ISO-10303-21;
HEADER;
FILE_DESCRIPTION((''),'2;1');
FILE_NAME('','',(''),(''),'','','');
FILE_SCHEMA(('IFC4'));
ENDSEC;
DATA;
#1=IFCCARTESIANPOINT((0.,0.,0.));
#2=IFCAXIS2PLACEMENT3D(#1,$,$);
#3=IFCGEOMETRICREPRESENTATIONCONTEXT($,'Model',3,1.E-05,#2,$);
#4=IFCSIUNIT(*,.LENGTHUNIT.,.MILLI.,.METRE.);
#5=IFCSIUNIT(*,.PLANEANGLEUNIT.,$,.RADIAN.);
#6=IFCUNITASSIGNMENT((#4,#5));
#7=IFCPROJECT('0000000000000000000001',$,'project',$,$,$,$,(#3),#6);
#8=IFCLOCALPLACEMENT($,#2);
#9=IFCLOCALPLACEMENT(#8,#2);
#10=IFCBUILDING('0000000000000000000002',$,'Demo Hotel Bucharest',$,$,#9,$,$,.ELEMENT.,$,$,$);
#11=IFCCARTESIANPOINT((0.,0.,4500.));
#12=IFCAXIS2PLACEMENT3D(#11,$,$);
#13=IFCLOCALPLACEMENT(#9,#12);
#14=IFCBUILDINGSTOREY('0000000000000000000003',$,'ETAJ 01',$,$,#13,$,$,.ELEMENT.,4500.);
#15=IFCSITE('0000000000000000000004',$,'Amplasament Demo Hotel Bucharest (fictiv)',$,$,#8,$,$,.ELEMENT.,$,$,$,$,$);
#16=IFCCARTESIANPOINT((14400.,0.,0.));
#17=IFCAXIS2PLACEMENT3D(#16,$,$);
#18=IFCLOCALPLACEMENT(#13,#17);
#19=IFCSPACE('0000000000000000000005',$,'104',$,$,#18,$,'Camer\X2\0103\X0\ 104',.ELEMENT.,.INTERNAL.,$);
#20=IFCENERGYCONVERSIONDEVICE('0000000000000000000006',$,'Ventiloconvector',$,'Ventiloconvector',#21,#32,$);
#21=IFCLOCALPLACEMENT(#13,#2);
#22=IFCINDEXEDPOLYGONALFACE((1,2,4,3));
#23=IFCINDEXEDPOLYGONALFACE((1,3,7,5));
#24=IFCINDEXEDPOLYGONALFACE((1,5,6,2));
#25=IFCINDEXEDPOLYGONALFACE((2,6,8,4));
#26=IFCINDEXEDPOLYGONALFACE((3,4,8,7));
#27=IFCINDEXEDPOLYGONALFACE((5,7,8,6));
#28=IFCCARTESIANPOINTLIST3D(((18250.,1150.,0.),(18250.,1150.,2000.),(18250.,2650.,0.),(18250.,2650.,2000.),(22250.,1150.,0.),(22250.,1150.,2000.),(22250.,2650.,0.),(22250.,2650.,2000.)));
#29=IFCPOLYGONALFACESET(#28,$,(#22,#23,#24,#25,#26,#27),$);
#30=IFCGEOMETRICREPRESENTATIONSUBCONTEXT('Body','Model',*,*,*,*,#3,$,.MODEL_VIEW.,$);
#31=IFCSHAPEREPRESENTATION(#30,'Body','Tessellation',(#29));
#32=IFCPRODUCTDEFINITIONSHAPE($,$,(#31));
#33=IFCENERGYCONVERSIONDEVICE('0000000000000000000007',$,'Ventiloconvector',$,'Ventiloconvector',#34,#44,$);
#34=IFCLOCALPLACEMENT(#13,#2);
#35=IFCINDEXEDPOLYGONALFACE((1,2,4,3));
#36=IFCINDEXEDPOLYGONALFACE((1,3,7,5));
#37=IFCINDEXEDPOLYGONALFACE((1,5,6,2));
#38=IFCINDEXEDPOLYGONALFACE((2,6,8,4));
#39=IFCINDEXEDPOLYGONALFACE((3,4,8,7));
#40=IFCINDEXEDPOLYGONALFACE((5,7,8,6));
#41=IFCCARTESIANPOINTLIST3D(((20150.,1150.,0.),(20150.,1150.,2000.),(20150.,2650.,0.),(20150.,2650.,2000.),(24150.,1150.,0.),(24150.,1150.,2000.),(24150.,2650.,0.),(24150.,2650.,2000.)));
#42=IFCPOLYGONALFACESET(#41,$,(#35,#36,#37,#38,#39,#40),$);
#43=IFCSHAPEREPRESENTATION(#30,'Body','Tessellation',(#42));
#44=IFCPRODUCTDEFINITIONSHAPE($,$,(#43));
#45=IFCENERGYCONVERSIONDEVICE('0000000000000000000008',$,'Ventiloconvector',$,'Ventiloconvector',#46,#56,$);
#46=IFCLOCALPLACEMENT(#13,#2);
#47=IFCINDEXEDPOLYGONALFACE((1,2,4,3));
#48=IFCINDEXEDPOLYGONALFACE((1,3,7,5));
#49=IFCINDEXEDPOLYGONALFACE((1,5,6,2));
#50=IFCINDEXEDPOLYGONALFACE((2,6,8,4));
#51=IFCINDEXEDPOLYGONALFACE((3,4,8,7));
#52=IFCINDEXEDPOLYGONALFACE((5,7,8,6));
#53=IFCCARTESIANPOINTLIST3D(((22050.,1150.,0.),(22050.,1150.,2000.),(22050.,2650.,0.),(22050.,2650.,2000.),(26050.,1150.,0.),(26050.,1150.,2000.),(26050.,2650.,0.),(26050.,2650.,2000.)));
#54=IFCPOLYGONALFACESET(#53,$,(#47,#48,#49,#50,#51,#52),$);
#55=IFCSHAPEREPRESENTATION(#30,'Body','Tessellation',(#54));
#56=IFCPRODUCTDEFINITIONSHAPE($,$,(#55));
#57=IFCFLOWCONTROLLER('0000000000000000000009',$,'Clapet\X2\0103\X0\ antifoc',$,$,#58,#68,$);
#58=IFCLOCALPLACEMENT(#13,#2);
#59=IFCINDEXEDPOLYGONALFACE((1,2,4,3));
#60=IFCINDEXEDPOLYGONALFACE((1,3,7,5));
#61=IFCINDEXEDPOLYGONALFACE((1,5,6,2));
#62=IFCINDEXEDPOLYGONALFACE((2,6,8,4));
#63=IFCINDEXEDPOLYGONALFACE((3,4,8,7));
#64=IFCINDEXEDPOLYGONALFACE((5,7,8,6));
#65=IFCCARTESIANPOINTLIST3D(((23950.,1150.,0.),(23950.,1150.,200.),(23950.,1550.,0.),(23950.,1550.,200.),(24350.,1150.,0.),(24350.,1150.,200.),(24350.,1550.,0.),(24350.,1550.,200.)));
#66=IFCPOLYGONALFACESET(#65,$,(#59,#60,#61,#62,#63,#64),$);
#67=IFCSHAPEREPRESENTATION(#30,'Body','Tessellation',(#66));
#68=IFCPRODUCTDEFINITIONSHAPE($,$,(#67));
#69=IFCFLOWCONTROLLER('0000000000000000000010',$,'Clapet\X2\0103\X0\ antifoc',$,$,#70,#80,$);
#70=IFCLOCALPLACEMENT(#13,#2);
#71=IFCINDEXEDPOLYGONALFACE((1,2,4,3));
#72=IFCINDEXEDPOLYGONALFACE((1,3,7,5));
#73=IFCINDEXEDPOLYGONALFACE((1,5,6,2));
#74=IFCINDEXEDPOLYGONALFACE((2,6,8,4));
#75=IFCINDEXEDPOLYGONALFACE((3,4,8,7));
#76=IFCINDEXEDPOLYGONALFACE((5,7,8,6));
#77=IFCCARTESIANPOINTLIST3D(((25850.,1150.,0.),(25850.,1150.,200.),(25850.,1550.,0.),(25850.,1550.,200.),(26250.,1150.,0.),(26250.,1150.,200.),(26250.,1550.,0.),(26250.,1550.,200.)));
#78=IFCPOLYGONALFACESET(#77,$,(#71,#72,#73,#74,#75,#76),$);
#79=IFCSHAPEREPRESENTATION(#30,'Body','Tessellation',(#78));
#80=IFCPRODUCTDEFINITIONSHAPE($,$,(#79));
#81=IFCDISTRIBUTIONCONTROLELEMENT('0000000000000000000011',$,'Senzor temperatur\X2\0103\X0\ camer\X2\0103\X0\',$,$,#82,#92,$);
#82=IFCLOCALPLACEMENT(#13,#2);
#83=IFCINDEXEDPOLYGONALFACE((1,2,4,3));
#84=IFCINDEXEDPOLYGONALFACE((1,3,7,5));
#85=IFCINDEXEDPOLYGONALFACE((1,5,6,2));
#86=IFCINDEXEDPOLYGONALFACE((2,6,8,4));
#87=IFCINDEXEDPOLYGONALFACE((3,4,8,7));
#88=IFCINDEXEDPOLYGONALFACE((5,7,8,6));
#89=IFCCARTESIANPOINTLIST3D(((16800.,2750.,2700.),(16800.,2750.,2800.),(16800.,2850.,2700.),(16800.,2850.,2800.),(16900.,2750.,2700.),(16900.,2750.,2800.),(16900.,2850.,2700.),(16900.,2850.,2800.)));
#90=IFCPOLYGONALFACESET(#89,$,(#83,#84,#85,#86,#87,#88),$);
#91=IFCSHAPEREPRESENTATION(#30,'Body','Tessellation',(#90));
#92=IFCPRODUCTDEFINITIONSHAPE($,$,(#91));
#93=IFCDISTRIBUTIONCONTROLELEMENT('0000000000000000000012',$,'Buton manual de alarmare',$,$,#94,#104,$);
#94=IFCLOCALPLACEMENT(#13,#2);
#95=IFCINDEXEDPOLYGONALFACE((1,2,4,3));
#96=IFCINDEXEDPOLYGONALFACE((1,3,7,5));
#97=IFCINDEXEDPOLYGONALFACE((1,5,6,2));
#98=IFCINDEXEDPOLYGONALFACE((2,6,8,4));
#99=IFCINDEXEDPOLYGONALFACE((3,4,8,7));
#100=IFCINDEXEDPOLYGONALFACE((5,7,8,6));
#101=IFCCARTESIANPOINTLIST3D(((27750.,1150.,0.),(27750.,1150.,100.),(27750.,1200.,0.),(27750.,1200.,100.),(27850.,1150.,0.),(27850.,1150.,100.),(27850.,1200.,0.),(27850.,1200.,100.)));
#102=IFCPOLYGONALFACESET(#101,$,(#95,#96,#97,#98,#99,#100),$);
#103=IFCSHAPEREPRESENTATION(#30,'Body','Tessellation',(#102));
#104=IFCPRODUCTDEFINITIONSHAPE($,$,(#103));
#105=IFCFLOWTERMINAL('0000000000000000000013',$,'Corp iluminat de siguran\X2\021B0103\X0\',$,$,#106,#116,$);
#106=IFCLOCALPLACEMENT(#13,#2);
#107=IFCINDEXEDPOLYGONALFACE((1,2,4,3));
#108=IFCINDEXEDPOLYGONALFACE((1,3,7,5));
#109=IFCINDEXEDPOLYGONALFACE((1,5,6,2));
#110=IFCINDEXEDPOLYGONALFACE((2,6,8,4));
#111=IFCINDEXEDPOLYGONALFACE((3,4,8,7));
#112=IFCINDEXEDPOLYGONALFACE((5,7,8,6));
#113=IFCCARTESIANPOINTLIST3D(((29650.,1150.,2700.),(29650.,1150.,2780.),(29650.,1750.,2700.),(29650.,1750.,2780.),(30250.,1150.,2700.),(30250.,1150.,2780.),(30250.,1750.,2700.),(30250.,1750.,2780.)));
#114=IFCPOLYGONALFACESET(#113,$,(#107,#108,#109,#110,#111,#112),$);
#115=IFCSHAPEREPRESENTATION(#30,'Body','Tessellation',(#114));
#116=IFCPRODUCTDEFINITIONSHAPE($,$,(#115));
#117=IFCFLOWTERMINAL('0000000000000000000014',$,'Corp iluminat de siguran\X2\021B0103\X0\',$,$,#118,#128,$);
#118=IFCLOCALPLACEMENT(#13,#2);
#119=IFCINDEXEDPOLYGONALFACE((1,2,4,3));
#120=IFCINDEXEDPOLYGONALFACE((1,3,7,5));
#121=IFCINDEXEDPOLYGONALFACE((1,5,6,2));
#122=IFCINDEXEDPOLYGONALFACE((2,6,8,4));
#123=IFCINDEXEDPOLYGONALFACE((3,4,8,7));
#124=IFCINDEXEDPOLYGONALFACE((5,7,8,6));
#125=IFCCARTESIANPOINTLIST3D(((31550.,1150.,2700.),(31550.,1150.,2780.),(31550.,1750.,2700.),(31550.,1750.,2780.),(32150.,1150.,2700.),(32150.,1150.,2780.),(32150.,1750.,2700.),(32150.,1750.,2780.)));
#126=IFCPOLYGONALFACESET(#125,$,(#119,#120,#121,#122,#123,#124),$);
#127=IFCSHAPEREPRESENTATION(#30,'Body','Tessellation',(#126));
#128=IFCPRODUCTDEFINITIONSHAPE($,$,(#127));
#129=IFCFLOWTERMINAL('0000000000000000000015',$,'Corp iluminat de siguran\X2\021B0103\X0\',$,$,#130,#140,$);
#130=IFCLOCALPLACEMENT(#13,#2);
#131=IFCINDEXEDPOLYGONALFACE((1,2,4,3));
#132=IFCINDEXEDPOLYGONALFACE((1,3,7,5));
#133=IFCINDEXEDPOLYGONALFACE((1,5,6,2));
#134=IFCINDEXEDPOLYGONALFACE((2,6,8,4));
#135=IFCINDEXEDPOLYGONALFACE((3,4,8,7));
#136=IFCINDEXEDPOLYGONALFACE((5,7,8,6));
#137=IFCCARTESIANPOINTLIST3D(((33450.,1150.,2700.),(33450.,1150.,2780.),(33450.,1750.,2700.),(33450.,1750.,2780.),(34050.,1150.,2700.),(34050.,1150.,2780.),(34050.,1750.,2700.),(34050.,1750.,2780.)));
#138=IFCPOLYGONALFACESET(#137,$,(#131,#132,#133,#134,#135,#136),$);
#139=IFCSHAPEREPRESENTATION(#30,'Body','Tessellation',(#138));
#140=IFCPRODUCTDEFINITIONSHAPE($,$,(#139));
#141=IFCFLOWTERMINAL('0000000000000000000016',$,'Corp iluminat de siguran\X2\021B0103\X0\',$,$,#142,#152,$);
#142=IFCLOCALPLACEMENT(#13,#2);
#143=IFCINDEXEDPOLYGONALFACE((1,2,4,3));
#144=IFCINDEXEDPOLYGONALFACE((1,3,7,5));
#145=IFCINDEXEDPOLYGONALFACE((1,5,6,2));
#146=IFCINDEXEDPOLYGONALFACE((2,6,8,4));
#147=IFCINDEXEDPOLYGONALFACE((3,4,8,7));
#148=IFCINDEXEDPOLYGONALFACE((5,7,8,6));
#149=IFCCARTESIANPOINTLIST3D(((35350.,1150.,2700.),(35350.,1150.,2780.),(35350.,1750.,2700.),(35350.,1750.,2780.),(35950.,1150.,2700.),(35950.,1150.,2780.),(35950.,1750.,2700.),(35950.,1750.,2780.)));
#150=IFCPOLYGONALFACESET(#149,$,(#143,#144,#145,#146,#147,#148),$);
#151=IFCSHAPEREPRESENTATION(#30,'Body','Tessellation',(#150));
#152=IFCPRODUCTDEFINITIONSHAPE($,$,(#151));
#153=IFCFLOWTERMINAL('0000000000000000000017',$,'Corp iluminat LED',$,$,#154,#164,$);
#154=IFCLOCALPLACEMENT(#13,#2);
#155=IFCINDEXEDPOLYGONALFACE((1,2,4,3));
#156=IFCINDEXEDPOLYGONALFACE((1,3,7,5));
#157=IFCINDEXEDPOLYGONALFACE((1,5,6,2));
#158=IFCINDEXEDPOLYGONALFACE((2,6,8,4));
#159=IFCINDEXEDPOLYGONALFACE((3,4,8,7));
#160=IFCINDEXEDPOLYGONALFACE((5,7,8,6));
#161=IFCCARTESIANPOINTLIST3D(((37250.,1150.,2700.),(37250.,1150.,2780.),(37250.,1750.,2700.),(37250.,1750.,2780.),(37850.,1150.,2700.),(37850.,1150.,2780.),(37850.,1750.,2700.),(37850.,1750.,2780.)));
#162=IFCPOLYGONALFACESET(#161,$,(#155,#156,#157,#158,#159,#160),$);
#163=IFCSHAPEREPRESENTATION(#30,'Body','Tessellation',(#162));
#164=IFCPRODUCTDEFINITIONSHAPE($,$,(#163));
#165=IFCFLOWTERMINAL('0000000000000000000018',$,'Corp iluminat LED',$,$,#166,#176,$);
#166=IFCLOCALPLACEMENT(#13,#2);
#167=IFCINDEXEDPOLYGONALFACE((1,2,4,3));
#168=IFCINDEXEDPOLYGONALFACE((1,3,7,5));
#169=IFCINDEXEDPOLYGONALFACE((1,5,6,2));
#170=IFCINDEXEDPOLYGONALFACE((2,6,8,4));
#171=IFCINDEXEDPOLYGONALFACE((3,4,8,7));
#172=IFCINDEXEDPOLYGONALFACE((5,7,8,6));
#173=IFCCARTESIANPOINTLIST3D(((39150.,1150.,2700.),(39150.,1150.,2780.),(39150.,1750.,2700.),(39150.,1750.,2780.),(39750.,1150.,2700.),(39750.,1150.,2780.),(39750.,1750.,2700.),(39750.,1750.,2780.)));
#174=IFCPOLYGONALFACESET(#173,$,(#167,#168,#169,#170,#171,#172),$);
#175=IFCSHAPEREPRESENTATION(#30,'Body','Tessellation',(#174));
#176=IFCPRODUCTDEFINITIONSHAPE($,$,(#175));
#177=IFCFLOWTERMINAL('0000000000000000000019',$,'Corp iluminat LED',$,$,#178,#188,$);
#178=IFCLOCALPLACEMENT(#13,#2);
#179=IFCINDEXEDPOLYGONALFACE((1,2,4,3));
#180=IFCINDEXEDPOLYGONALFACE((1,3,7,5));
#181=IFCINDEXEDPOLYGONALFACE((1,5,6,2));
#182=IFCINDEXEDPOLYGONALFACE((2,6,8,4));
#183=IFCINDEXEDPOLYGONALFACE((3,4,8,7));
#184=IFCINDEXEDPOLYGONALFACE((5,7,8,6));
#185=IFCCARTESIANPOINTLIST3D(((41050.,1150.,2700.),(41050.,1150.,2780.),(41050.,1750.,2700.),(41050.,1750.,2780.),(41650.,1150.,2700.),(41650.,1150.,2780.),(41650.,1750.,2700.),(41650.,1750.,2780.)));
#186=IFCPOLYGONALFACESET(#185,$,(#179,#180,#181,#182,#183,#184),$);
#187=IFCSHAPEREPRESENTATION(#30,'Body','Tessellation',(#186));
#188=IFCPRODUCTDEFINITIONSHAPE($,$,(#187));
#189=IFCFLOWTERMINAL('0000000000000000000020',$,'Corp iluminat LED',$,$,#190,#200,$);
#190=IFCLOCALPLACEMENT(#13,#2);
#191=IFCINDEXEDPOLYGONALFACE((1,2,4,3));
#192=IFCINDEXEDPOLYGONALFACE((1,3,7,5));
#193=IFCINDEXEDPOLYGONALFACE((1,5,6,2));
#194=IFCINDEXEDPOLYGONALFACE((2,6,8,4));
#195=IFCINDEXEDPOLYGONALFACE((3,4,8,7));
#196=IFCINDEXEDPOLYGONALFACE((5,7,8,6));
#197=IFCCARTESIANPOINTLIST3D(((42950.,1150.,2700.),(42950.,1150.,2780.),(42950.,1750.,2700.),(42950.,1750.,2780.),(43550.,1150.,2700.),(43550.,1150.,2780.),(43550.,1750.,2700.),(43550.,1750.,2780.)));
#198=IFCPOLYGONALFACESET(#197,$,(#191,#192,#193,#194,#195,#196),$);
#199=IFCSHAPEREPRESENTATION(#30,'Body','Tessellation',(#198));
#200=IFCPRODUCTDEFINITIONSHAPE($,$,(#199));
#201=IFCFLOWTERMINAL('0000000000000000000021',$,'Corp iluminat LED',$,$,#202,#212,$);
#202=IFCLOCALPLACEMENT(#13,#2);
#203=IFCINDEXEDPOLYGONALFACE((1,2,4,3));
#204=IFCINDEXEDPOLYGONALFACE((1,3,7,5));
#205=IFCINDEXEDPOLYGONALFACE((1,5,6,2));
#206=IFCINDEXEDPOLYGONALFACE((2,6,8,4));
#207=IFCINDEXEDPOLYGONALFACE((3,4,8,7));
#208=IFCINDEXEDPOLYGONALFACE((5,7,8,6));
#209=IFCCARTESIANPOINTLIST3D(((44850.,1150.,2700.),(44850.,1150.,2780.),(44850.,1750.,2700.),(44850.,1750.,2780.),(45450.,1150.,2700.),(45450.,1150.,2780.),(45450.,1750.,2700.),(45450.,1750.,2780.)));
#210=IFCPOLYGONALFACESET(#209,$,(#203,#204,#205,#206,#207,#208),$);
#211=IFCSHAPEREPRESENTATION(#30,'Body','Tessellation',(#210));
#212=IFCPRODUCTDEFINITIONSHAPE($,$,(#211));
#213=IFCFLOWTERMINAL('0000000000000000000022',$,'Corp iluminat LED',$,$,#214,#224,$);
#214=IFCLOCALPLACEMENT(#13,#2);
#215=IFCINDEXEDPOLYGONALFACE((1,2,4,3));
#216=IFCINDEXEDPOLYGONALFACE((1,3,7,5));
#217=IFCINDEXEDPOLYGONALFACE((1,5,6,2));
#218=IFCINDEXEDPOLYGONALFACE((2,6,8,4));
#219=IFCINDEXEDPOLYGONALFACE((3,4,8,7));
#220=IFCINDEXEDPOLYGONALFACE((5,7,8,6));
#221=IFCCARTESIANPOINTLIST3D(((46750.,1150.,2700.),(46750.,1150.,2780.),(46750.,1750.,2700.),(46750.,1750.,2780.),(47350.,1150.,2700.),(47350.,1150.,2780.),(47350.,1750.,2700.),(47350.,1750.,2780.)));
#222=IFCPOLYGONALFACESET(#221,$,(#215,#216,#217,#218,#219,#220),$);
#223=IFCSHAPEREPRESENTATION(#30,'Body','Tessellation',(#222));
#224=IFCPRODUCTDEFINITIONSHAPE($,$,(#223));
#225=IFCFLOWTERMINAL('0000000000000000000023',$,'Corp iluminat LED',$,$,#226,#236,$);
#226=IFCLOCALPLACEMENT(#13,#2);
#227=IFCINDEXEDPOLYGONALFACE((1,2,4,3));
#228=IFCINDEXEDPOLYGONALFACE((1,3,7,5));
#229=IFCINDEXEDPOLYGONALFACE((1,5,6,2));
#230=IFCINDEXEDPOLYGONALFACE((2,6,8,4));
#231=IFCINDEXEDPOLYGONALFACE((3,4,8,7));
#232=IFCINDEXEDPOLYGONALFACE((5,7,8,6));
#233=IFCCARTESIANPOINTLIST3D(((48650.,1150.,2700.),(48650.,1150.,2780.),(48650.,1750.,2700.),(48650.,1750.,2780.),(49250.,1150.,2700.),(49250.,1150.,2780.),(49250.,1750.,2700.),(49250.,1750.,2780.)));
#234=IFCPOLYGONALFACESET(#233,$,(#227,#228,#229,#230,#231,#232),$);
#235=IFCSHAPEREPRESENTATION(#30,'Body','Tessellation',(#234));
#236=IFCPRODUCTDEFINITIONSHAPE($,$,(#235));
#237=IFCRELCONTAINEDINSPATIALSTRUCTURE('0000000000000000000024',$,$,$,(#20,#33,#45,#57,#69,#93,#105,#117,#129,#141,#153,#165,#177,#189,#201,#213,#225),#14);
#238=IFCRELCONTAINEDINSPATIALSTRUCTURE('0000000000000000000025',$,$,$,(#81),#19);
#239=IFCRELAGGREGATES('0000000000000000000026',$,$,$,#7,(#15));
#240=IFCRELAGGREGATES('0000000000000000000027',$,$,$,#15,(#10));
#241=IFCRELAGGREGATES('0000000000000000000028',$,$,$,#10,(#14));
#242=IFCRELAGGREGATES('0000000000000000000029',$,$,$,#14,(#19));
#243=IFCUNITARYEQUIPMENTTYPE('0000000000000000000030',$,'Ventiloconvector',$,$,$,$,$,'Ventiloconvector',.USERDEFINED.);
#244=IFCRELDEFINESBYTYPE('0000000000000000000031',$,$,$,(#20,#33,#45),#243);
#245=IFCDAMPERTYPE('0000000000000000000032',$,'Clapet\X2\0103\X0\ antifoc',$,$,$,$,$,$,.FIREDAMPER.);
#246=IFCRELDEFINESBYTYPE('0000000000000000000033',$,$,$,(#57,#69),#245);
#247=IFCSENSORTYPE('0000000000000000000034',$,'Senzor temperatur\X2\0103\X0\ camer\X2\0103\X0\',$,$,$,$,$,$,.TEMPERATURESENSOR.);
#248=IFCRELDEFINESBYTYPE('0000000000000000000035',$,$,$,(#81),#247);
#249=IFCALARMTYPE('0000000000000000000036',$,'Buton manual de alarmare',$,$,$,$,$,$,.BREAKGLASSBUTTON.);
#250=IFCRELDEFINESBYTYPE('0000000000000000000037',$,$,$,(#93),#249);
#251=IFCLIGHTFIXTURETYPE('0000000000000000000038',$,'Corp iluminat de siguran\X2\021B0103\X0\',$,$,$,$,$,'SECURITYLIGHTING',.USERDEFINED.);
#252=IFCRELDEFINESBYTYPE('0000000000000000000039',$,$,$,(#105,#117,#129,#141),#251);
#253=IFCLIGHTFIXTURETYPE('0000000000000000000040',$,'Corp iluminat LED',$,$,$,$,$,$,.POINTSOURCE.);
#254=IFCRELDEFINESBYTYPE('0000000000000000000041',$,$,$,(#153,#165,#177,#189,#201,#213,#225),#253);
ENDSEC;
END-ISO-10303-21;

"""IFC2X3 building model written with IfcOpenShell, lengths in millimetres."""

from ifc_helpers import new_model, si_unit, frame, frame_2d, origin, place, context, subcontext, project, spatial, rectangle, extrude, type_object, element, save


model = new_model("IFC2X3")

# Units and contexts
model_context = context("Model", 3, precision=1e-05, world=origin())
body_context = subcontext(model_context, "Body", "Model", "MODEL_VIEW")
ifc_project = project(units=[si_unit("LENGTHUNIT", "METRE", prefix="MILLI"), si_unit("PLANEANGLEUNIT", "RADIAN")], contexts=[model_context])

# Site, building, storey
site_placement = place(None, origin())
site = spatial("IfcSite", under=ifc_project, at=site_placement, Name="Amplasament Demo Hotel Bucharest (fictiv)", CompositionType="ELEMENT")
building_placement = place(site_placement, origin())
building = spatial("IfcBuilding", under=site, at=building_placement, Name="Demo Hotel Bucharest", CompositionType="ELEMENT")
storey_placement = place(building_placement, frame((0.0, 0.0, 4500.0)))
storey = spatial("IfcBuildingStorey", under=building, at=storey_placement, Name="ETAJ 01", CompositionType="ELEMENT", Elevation=4500.0)

# Energy conversion devices
unitary_equipment_type = type_object("IfcUnitaryEquipmentType", Name="Ventiloconvector", ElementType="Ventiloconvector", PredefinedType="USERDEFINED")
for number, where, name in (
    (1, (18250.0, 1150.0, 0.0), "Ventiloconvector"),
    (2, (20150.0, 1150.0, 0.0), "Ventiloconvector"),
    (3, (22050.0, 1150.0, 0.0), "Ventiloconvector"),
):
    element("IfcEnergyConversionDevice", number, at=place(storey_placement, frame(where)), inside=storey, type_object=unitary_equipment_type, Name=name, ObjectType="Ventiloconvector", context=body_context, shape_type="SweptSolid", body=[
        extrude(rectangle(XDim=4000.0, YDim=1500.0, at=frame_2d((2000.0, 750.0))), origin(), (0.0, 0.0, 1.0), 2000.0),
    ])

# Flow controllers
damper_type = type_object("IfcDamperType", Name="Clapetă antifoc", PredefinedType="FIREDAMPER")
for number, where, name in (
    (4, (23950.0, 1150.0, 0.0), "Clapetă antifoc"),
    (5, (25850.0, 1150.0, 0.0), "Clapetă antifoc"),
):
    element("IfcFlowController", number, at=place(storey_placement, frame(where)), inside=storey, type_object=damper_type, Name=name, context=body_context, shape_type="SweptSolid", body=[
        extrude(rectangle(XDim=400.0, YDim=400.0, at=frame_2d((200.0, 200.0))), origin(), (0.0, 0.0, 1.0), 200.0),
    ])

# Shared definitions
space_placement = place(storey_placement, frame((14400.0, 0.0, 0.0)))
space = spatial("IfcSpace", under=storey, at=space_placement, Name="104", LongName="Cameră 104", CompositionType="ELEMENT", InteriorOrExteriorSpace="INTERNAL")

# Distribution control elements
sensor_type = type_object("IfcSensorType", Name="Senzor temperatură cameră", PredefinedType="TEMPERATURESENSOR")
distribution_control_element_1_placement = place(storey_placement, frame((16800.0, 2750.0, 2700.0)))
element("IfcDistributionControlElement", 6, at=distribution_control_element_1_placement, inside=space, type_object=sensor_type, Name="Senzor temperatură cameră", context=body_context, shape_type="SweptSolid", body=[
    extrude(rectangle(XDim=100.0, YDim=100.0, at=frame_2d((50.0, 50.0))), origin(), (0.0, 0.0, 1.0), 100.0),
])
alarm_type = type_object("IfcAlarmType", Name="Buton manual de alarmare", PredefinedType="BREAKGLASSBUTTON")
distribution_control_element_2_placement = place(storey_placement, frame((27750.0, 1150.0, 0.0)))
element("IfcDistributionControlElement", 7, at=distribution_control_element_2_placement, inside=storey, type_object=alarm_type, Name="Buton manual de alarmare", context=body_context, shape_type="SweptSolid", body=[
    extrude(rectangle(XDim=100.0, YDim=50.0, at=frame_2d((50.0, 25.0))), origin(), (0.0, 0.0, 1.0), 100.0),
])

# Flow terminals
light_fixture_type_1 = type_object("IfcLightFixtureType", Name="Corp iluminat de siguranță", ElementType="SECURITYLIGHTING", PredefinedType="USERDEFINED")
for number, where, name in (
    (8, (29650.0, 1150.0, 2700.0), "Corp iluminat de siguranță"),
    (9, (31550.0, 1150.0, 2700.0), "Corp iluminat de siguranță"),
    (10, (33450.0, 1150.0, 2700.0), "Corp iluminat de siguranță"),
    (11, (35350.0, 1150.0, 2700.0), "Corp iluminat de siguranță"),
):
    element("IfcFlowTerminal", number, at=place(storey_placement, frame(where)), inside=storey, type_object=light_fixture_type_1, Name=name, context=body_context, shape_type="SweptSolid", body=[
        extrude(rectangle(XDim=600.0, YDim=600.0, at=frame_2d((300.0, 300.0))), origin(), (0.0, 0.0, 1.0), 80.0),
    ])
light_fixture_type_2 = type_object("IfcLightFixtureType", Name="Corp iluminat LED", PredefinedType="POINTSOURCE")
for number, where, name in (
    (12, (37250.0, 1150.0, 2700.0), "Corp iluminat LED"),
    (13, (39150.0, 1150.0, 2700.0), "Corp iluminat LED"),
    (14, (41050.0, 1150.0, 2700.0), "Corp iluminat LED"),
    (15, (42950.0, 1150.0, 2700.0), "Corp iluminat LED"),
    (16, (44850.0, 1150.0, 2700.0), "Corp iluminat LED"),
    (17, (46750.0, 1150.0, 2700.0), "Corp iluminat LED"),
    (18, (48650.0, 1150.0, 2700.0), "Corp iluminat LED"),
):
    element("IfcFlowTerminal", number, at=place(storey_placement, frame(where)), inside=storey, type_object=light_fixture_type_2, Name=name, context=body_context, shape_type="SweptSolid", body=[
        extrude(rectangle(XDim=600.0, YDim=600.0, at=frame_2d((300.0, 300.0))), origin(), (0.0, 0.0, 1.0), 80.0),
    ])

save(model, "model.ifc")
